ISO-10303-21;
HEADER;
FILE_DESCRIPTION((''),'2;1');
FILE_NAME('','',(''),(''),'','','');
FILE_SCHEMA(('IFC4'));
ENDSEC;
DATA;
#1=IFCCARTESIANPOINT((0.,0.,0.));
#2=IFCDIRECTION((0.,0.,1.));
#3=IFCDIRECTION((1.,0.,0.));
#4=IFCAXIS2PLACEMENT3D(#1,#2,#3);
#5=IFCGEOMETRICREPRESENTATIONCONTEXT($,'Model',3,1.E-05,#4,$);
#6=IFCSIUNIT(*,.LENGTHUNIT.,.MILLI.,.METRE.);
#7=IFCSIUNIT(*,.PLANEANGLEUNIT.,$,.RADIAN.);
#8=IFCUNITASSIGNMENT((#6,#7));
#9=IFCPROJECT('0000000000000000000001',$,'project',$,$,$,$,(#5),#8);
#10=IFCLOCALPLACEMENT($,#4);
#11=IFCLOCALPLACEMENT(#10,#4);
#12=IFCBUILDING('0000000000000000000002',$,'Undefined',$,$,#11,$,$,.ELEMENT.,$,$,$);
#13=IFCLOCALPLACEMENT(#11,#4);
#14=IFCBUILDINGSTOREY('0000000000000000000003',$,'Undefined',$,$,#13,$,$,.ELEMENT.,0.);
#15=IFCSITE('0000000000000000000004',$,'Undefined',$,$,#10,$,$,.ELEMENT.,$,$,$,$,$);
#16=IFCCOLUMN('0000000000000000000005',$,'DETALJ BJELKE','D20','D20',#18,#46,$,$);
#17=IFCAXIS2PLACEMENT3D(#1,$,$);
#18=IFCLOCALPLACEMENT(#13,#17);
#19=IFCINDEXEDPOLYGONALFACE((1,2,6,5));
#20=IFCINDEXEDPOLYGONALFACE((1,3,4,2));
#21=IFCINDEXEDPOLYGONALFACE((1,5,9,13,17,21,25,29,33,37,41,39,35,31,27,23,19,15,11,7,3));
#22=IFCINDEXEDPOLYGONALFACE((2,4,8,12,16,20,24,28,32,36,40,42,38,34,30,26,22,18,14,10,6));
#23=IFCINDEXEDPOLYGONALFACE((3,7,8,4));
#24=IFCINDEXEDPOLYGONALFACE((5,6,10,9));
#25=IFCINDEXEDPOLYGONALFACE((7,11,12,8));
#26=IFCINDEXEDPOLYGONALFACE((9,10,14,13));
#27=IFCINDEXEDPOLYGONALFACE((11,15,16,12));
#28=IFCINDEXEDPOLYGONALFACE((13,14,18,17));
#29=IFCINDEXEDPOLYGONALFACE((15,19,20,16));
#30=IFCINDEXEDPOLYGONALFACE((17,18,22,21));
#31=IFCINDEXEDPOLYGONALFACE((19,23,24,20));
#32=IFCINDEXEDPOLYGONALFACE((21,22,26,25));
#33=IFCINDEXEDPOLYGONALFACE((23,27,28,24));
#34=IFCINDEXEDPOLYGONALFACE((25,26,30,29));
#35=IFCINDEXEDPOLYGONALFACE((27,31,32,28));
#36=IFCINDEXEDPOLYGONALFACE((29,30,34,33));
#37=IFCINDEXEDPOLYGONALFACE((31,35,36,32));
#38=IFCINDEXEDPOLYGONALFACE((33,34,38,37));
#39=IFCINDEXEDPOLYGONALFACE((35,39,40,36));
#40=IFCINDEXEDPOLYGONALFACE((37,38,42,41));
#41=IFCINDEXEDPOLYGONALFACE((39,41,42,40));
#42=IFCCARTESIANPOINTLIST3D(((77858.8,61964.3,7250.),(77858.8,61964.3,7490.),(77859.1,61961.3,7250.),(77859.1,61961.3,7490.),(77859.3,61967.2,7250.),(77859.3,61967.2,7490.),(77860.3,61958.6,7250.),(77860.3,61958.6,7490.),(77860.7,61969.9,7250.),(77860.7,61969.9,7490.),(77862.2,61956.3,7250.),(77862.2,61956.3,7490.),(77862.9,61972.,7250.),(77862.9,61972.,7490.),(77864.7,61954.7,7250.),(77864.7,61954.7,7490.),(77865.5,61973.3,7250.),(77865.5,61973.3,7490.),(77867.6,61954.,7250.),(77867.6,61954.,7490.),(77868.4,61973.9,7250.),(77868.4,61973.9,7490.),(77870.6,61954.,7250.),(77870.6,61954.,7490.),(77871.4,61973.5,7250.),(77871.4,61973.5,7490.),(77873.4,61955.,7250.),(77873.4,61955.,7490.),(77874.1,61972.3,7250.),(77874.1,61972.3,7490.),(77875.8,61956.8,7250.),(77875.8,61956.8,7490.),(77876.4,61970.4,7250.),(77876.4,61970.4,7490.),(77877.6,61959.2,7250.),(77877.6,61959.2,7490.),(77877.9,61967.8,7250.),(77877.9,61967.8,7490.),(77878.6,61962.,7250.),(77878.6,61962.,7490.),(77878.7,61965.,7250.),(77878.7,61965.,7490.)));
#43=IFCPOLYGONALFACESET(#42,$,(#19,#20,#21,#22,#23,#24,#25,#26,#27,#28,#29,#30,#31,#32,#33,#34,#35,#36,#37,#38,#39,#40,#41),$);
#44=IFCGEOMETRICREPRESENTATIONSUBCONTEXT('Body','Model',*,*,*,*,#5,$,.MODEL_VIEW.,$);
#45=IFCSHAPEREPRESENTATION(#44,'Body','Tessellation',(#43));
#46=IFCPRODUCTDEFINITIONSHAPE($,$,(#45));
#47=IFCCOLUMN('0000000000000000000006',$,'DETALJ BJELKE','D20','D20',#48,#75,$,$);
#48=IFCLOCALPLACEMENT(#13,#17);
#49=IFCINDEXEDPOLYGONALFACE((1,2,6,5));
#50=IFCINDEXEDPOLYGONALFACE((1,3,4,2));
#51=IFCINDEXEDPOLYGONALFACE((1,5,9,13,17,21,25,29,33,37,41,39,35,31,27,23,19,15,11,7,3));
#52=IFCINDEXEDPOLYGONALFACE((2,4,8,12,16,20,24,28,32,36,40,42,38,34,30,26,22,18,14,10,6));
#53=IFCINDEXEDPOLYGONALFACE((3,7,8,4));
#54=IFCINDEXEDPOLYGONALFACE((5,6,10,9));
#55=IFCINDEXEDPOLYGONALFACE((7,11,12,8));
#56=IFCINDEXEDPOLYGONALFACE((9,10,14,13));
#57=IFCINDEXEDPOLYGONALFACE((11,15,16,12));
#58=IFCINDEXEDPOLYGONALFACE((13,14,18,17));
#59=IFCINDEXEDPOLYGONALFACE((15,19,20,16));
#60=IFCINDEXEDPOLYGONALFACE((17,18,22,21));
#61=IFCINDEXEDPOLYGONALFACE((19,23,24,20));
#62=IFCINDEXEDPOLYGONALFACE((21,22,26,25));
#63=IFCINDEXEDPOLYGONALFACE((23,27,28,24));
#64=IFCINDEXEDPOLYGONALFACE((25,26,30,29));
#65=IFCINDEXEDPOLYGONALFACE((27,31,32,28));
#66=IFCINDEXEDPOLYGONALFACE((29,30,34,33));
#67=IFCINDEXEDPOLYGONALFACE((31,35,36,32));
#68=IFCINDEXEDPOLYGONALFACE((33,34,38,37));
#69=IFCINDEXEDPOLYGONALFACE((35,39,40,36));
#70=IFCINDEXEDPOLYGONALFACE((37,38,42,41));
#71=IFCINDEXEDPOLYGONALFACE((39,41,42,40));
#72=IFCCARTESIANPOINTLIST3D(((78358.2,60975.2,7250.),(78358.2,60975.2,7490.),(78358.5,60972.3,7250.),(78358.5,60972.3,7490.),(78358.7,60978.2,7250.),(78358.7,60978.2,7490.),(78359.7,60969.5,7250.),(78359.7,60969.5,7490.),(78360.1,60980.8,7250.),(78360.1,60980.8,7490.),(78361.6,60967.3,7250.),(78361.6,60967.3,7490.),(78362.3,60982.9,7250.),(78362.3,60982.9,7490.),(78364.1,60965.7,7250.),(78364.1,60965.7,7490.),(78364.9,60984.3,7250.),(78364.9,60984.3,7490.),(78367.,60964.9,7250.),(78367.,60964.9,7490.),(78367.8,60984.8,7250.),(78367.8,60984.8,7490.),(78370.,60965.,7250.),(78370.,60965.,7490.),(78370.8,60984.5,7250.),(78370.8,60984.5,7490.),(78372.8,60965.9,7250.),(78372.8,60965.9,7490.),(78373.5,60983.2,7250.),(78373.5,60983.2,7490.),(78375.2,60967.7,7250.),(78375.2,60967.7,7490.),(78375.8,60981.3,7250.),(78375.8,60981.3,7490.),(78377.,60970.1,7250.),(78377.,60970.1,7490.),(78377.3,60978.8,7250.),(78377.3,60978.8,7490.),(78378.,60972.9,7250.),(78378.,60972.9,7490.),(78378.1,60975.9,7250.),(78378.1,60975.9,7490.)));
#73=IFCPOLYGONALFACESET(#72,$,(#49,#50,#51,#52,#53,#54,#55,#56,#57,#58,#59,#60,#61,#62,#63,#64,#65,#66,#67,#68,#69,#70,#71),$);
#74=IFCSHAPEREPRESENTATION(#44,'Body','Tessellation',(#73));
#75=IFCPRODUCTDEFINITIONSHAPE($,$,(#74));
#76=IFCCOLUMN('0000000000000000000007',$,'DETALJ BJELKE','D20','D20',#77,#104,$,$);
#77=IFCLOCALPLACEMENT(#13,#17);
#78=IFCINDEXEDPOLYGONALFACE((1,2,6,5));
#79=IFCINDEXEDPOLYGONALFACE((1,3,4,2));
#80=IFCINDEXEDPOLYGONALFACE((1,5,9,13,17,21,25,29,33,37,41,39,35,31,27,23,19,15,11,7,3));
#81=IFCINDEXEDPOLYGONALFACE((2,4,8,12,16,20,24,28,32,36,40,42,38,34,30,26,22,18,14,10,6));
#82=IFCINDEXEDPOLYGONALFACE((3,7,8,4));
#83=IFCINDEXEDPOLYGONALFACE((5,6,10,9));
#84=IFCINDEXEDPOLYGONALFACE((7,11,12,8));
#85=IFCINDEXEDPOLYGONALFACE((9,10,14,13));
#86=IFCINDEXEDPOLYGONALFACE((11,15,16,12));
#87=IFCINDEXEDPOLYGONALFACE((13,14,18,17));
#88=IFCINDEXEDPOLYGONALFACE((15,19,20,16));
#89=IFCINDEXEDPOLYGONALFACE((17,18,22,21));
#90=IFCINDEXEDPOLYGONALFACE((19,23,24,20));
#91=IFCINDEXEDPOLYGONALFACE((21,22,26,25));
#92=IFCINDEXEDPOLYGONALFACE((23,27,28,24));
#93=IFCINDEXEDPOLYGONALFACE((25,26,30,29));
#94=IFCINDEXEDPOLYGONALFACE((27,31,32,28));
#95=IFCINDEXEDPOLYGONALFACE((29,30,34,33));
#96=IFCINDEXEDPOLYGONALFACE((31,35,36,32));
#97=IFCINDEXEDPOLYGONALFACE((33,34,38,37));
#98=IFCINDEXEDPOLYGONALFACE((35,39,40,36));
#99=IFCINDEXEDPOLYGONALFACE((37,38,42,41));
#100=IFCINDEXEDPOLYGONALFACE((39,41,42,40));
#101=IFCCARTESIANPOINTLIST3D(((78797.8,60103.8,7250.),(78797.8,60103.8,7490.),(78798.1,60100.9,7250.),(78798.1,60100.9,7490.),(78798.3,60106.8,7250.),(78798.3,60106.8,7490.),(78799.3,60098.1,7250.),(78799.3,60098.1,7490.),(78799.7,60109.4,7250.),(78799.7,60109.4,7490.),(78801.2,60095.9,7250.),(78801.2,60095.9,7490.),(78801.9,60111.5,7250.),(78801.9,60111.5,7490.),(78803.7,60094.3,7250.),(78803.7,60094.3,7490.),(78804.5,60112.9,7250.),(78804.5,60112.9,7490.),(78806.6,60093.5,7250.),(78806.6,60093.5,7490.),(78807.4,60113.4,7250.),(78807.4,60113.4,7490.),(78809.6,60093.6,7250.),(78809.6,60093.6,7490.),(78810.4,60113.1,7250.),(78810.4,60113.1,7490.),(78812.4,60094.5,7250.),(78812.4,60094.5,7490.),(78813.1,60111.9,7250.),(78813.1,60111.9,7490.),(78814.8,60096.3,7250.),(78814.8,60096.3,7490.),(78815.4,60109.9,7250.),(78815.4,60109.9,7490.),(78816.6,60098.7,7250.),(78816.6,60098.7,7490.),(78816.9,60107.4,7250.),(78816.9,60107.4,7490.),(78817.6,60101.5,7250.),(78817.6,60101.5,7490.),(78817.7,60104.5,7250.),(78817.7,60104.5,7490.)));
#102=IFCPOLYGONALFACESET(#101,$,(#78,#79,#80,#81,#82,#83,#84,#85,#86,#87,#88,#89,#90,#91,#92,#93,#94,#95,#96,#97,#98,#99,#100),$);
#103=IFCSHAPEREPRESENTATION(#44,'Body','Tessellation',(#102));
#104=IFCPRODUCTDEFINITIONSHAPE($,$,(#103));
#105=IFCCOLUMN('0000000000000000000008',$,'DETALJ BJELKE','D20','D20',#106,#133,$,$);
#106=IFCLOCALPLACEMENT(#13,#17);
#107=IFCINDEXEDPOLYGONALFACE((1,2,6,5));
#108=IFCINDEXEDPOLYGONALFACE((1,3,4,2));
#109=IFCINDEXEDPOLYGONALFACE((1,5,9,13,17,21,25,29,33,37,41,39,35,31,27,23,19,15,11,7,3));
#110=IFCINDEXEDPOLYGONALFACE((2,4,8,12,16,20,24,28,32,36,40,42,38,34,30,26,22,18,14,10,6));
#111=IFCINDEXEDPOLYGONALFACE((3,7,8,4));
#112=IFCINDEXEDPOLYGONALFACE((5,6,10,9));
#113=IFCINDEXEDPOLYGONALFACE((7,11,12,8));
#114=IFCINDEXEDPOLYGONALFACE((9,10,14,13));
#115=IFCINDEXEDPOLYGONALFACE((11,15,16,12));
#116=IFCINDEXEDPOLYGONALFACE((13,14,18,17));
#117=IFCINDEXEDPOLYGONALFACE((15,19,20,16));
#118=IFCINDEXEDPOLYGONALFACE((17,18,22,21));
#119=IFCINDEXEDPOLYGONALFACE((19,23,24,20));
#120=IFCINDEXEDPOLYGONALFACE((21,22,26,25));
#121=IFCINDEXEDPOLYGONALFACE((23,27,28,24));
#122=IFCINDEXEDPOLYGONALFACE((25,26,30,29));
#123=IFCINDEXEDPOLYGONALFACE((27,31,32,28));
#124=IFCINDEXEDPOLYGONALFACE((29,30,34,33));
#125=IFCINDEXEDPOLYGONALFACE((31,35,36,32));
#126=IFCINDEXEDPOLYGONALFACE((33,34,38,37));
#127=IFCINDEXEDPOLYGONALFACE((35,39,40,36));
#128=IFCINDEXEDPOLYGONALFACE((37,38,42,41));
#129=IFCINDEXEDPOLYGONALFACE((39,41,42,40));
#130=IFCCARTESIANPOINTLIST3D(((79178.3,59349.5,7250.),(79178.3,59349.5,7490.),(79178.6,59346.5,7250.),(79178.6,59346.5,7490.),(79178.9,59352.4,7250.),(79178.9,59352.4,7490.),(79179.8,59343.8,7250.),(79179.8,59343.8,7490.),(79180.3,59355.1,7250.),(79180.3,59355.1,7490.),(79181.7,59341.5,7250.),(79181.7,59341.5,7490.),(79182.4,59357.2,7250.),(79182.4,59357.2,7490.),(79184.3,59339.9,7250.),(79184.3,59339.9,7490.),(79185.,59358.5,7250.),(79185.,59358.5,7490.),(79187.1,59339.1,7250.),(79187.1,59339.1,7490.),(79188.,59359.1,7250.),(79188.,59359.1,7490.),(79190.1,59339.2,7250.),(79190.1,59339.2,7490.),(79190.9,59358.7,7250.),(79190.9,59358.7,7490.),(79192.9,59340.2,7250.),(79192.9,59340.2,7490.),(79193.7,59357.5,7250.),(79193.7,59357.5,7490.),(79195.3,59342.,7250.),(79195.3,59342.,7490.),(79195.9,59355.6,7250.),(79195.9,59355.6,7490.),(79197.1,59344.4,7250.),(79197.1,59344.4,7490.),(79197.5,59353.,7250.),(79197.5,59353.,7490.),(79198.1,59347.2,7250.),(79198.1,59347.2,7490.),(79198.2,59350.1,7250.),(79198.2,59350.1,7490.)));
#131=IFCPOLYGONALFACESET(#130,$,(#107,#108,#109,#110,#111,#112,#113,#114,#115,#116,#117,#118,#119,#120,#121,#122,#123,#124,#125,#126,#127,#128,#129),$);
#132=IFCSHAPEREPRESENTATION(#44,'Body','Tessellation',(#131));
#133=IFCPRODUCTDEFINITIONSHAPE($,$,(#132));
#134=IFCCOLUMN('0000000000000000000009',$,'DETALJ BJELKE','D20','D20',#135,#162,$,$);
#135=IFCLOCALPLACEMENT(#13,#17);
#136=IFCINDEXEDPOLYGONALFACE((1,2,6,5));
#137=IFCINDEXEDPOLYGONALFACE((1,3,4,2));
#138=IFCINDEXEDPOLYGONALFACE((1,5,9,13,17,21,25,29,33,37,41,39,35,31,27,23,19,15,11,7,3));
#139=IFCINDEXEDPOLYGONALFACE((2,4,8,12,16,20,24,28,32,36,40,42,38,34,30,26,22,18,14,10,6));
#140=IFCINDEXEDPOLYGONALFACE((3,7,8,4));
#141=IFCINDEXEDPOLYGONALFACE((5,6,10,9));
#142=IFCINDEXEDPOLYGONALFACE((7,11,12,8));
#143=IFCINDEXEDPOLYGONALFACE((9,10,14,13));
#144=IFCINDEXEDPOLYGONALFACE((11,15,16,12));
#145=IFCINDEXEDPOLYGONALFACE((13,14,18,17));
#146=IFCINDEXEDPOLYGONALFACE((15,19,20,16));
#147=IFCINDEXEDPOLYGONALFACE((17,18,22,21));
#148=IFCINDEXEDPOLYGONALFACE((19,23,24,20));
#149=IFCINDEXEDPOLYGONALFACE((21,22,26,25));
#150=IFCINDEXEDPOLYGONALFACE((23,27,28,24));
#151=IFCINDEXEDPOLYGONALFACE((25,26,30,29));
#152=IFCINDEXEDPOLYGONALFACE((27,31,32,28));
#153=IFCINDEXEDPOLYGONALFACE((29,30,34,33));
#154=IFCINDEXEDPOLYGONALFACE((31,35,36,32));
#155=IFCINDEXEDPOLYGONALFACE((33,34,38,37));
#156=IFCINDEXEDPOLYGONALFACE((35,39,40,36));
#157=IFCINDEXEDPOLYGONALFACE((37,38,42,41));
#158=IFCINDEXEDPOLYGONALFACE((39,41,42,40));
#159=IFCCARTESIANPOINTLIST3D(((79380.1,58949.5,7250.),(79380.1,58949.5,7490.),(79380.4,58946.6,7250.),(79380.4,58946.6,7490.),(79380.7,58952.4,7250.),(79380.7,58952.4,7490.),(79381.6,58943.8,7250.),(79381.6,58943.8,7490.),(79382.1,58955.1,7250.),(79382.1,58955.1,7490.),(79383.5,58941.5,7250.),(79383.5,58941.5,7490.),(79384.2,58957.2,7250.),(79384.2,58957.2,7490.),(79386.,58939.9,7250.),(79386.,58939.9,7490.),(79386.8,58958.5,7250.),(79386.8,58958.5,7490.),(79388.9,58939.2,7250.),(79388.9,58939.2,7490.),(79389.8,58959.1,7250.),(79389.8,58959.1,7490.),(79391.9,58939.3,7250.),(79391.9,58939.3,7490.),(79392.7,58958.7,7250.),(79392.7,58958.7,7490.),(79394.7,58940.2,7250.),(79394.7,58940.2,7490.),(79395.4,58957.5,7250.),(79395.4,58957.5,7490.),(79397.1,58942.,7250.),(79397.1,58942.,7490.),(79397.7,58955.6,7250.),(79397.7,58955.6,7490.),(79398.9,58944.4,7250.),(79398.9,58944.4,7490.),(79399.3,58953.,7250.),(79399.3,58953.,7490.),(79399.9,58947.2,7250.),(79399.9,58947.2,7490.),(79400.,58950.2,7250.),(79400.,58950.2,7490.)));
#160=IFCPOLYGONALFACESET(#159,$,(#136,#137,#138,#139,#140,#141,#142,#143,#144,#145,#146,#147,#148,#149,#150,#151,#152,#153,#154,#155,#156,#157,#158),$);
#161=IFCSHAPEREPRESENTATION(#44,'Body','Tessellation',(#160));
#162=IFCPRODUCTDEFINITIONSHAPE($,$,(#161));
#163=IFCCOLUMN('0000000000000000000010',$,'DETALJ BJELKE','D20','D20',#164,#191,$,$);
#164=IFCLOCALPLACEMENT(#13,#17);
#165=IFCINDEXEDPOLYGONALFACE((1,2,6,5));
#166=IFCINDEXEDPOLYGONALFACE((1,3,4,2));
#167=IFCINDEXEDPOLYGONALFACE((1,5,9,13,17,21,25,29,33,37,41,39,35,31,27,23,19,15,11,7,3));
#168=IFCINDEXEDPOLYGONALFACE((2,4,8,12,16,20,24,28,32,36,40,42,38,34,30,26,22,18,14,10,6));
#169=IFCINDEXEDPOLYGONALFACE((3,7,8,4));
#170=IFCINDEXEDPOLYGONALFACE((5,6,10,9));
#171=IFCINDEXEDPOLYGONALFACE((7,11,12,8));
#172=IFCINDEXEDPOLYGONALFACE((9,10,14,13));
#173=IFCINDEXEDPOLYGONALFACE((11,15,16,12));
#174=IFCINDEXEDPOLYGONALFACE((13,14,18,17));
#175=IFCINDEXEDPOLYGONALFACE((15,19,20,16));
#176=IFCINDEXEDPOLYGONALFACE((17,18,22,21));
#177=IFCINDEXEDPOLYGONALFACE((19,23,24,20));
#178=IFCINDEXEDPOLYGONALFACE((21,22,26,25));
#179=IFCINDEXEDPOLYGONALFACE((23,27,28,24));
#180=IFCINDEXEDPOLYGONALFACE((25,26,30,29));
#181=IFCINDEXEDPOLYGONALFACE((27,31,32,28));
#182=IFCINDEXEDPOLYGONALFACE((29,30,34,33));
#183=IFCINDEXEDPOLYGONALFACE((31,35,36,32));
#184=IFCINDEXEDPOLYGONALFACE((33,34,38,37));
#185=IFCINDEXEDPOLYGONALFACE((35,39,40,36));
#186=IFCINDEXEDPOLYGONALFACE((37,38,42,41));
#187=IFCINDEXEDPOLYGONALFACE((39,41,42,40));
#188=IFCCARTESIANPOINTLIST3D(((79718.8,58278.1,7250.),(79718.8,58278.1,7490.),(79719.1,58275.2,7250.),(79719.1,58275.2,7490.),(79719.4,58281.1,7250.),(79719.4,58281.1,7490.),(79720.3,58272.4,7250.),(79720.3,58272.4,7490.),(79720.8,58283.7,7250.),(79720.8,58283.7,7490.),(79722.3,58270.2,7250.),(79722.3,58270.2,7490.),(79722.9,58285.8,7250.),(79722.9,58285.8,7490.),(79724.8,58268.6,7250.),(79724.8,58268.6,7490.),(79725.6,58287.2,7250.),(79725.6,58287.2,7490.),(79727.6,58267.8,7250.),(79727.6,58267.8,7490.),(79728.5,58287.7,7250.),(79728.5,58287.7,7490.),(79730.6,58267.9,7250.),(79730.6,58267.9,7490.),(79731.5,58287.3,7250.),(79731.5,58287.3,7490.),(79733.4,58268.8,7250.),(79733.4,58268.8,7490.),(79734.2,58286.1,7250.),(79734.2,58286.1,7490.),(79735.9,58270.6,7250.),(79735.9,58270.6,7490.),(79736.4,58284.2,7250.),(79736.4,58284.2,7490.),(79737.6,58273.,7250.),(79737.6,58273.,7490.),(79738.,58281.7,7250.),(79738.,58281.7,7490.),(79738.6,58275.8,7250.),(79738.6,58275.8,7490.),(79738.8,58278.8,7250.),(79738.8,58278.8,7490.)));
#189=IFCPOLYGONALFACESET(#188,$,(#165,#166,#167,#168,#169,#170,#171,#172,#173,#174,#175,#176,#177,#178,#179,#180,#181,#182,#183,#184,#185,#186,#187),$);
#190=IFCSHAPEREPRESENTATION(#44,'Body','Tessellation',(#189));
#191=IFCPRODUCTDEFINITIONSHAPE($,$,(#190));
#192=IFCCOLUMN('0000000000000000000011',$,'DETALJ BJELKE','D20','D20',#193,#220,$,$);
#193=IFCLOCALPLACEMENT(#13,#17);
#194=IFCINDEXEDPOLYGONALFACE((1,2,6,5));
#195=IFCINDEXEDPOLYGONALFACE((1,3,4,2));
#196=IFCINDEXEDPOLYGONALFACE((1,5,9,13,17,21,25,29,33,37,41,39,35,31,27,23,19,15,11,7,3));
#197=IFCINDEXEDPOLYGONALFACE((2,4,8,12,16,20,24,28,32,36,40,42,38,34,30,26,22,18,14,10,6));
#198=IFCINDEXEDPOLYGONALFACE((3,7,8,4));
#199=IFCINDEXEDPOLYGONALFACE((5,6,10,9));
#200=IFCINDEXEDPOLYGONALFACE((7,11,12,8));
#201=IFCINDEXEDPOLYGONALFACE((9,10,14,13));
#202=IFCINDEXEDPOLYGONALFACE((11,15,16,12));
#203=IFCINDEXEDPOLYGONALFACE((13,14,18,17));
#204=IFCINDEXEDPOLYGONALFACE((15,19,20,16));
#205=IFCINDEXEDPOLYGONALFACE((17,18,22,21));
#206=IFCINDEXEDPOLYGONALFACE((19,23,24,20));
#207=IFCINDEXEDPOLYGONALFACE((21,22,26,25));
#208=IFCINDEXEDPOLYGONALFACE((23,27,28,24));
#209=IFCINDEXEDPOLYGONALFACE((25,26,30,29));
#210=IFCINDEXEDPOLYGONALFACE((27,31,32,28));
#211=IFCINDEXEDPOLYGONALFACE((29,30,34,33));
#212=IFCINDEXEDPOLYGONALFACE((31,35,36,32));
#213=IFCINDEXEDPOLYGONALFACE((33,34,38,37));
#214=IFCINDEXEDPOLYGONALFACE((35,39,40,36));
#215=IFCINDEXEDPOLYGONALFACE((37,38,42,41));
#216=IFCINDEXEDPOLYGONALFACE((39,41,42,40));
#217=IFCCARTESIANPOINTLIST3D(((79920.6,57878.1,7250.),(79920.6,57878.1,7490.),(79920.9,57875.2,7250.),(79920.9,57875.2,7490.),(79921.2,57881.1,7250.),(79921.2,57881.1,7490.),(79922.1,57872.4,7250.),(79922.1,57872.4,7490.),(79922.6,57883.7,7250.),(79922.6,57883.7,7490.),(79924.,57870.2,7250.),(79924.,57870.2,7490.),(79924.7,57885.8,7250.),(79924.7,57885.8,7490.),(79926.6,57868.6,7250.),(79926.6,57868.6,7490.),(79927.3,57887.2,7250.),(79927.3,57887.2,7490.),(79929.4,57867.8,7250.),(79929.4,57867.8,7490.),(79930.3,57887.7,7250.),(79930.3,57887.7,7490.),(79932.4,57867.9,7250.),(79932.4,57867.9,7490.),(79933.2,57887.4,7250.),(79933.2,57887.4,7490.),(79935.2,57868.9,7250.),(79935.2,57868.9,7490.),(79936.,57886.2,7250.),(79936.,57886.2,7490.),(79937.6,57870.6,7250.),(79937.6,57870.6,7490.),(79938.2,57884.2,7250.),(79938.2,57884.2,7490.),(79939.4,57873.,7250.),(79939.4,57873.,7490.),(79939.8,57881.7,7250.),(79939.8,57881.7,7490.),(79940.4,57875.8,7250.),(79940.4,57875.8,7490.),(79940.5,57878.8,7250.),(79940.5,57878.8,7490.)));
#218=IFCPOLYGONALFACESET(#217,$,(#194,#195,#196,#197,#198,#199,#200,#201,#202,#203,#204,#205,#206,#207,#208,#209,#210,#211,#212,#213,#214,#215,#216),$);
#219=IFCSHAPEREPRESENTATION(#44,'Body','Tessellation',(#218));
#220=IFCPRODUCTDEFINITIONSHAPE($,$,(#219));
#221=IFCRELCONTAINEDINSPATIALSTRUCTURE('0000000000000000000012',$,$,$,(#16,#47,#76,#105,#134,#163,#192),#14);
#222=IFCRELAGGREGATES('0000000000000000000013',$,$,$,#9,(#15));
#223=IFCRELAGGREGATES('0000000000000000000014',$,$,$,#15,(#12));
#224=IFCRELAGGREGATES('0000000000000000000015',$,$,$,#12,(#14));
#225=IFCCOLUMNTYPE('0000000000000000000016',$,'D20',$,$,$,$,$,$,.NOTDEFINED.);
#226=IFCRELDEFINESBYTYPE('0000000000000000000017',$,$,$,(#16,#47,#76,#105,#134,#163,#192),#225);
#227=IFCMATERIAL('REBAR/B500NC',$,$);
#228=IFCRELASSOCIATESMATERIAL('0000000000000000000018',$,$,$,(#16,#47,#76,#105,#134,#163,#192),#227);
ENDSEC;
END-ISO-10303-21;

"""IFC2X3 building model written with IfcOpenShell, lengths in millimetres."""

from ifc_helpers import new_model, si_unit, frame, origin_with_axes, origin_2d_with_axis, place, context, subcontext, project, spatial, circle, extrude, material, type_object, element, save


model = new_model("IFC2X3")

# Units and contexts
model_context = context("Model", 3, precision=1e-05, world=origin_with_axes())
body_context = subcontext(model_context, "Body", "Model", "MODEL_VIEW")
ifc_project = project(units=[si_unit("LENGTHUNIT", "METRE", prefix="MILLI"), si_unit("PLANEANGLEUNIT", "RADIAN")], contexts=[model_context])

# Site, building, storey
site_placement = place(None, origin_with_axes())
site = spatial("IfcSite", under=ifc_project, at=site_placement, Name="Undefined", CompositionType="ELEMENT")
building_placement = place(site_placement, origin_with_axes())
building = spatial("IfcBuilding", under=site, at=building_placement, Name="Undefined", CompositionType="ELEMENT")
storey_placement = place(building_placement, origin_with_axes())
storey = spatial("IfcBuildingStorey", under=building, at=storey_placement, Name="Undefined", CompositionType="ELEMENT", Elevation=0.0)

# Columns
ifc_material_1 = material(Name="REBAR/B500NC")
column_type_1 = type_object("IfcColumnType", Name="D20", PredefinedType="NOTDEFINED")
for number, where, z_axis, x_axis, name in (
    (1, (77868.8, 61963.9, 7250.0), (0.0, 0.0, 1.0), (-0.886365, -0.462987, 0.0), "DETALJ BJELKE"),
    (2, (78368.2, 60974.8, 7250.0), (0.0, 0.0, 1.0), (-0.886365, -0.462987, 0.0), "DETALJ BJELKE"),
    (3, (78807.8, 60103.4, 7250.0), (0.0, 0.0, 1.0), (-0.886365, -0.462987, 0.0), "DETALJ BJELKE"),
    (4, (79188.3, 59349.1, 7250.0), (0.0, 0.0, 1.0), (-0.886365, -0.462987, 0.0), "DETALJ BJELKE"),
    (5, (79390.1, 58949.1, 7250.0), (0.0, 0.0, 1.0), (-0.886365, -0.462987, 0.0), "DETALJ BJELKE"),
    (6, (79728.8, 58277.7, 7250.0), (0.0, 0.0, 1.0), (-0.886365, -0.462987, 0.0), "DETALJ BJELKE"),
    (7, (79930.6, 57877.7, 7250.0), (0.0, 0.0, 1.0), (-0.886365, -0.462987, 0.0), "DETALJ BJELKE"),
):
    element("IfcColumn", number, at=place(storey_placement, frame(where, z_axis=z_axis, x_axis=x_axis)), inside=storey, type_object=column_type_1, material=ifc_material_1, Name=name, Description="D20", ObjectType="D20", context=body_context, shape_type="SweptSolid", body=[
        extrude(circle(Radius=10.0, at=origin_2d_with_axis()), frame((0.0, 0.0, 240.0), z_axis=(0.0, 0.0, -1.0), x_axis=(0.0, 1.0, 0.0)), (0.0, 0.0, 1.0), 240.0),
    ])

save(model, "model.ifc")
